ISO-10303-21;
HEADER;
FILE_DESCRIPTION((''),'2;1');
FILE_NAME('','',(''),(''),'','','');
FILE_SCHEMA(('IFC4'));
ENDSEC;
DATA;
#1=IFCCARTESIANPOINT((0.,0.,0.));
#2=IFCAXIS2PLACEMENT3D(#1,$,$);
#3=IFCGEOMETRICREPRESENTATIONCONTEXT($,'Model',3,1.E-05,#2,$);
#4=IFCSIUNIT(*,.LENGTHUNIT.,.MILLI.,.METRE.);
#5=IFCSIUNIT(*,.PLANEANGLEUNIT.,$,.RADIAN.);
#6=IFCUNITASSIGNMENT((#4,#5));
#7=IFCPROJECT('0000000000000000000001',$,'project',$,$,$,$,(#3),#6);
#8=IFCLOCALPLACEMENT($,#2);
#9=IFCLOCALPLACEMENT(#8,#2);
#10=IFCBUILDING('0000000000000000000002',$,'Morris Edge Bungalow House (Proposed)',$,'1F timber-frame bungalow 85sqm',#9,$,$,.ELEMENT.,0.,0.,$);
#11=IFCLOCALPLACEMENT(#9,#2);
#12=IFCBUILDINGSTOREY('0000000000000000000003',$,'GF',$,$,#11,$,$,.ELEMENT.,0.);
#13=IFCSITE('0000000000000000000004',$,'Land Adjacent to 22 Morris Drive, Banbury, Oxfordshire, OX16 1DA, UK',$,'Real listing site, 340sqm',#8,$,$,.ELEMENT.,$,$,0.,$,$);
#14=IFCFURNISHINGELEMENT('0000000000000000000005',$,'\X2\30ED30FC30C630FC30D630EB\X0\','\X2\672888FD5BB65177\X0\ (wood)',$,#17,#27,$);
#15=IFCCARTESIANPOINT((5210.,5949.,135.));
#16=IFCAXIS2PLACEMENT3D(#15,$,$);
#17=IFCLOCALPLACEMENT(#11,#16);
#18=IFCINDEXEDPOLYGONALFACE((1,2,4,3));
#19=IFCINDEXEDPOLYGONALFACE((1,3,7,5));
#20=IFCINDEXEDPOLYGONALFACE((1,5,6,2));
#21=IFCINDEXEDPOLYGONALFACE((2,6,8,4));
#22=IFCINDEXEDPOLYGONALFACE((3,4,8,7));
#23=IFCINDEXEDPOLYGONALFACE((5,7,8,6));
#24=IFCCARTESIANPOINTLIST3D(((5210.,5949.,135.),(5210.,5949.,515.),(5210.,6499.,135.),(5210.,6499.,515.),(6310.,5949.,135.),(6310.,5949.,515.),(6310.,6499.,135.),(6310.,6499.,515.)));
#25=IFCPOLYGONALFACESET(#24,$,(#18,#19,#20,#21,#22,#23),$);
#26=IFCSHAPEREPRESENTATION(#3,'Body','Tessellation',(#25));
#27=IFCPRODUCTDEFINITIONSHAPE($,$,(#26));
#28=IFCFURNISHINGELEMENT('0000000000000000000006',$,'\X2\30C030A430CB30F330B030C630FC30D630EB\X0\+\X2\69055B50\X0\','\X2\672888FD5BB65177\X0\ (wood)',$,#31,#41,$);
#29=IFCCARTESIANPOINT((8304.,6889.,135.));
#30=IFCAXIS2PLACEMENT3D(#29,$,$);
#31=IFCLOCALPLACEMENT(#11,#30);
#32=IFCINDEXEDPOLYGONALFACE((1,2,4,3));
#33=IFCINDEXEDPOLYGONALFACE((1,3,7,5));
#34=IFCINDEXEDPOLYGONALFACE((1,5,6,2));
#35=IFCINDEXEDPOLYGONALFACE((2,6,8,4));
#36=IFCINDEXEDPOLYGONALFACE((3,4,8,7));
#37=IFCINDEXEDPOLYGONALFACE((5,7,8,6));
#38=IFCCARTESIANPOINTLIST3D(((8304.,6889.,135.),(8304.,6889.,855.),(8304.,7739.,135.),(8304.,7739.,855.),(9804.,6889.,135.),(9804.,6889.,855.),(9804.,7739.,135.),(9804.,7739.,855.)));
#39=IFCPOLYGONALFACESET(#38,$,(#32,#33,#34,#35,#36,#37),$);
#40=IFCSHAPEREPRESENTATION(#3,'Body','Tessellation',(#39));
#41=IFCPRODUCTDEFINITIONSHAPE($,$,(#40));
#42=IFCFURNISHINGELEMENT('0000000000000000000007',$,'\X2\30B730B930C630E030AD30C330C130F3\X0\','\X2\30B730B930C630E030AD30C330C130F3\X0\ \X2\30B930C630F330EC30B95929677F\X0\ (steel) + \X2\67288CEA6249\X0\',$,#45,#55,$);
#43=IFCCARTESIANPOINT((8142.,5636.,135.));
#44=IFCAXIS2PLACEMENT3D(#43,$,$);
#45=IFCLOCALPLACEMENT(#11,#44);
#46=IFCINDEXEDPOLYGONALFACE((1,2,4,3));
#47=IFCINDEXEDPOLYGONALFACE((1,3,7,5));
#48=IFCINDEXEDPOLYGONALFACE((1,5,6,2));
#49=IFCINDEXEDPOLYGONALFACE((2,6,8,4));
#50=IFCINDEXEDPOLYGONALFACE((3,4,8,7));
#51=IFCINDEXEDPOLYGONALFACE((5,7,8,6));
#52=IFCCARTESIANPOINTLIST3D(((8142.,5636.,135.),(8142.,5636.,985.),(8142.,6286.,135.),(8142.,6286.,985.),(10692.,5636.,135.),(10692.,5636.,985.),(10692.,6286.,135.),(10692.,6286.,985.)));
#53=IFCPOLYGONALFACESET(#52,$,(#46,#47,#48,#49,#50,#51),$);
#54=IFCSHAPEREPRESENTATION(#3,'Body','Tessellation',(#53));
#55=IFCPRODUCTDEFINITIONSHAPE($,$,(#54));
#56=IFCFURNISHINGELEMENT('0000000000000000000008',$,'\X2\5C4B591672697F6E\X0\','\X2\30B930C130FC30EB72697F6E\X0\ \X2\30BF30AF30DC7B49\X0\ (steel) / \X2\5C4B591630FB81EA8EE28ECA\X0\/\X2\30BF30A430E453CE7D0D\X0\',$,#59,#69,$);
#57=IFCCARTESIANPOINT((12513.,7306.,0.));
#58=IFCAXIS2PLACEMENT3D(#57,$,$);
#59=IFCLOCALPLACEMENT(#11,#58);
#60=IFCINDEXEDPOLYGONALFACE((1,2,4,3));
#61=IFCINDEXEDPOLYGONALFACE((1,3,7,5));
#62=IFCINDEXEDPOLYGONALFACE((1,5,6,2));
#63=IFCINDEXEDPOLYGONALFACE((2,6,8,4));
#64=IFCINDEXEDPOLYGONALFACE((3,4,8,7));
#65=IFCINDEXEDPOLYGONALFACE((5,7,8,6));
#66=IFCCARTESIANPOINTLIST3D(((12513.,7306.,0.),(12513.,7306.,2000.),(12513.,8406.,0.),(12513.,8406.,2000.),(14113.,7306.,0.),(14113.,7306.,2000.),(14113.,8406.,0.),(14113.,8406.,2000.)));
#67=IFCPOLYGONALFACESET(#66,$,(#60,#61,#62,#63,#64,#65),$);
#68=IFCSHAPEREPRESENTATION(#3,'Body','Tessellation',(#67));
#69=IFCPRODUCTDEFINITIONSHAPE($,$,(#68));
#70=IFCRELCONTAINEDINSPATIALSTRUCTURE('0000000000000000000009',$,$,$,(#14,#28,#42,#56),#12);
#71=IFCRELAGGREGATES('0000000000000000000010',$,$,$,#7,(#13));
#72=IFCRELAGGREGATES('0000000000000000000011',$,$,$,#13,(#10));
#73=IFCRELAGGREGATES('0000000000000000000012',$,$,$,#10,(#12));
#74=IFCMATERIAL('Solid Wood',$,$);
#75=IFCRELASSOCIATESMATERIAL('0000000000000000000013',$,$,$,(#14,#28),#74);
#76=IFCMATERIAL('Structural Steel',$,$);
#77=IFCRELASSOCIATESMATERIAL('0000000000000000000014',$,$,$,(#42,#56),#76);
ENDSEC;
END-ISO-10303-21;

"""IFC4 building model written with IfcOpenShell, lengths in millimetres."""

from ifc_helpers import new_model, si_unit, frame, frame_2d, origin, place, context, project, spatial, rectangle, extrude, material, element, save


model = new_model("IFC4")

# Units and contexts
model_context = context("Model", 3, precision=1e-05, world=origin())
ifc_project = project(units=[si_unit("LENGTHUNIT", "METRE", prefix="MILLI"), si_unit("PLANEANGLEUNIT", "RADIAN")], contexts=[model_context])

# Site, building, storey
site_placement = place(None, origin())
site = spatial("IfcSite", under=ifc_project, at=site_placement, Name="Land Adjacent to 22 Morris Drive, Banbury, Oxfordshire, OX16 1DA, UK", ObjectType="Real listing site, 340sqm", CompositionType="ELEMENT", RefElevation=0.0)
building_placement = place(site_placement, origin())
building = spatial("IfcBuilding", under=site, at=building_placement, Name="Morris Edge Bungalow House (Proposed)", ObjectType="1F timber-frame bungalow 85sqm", CompositionType="ELEMENT", ElevationOfRefHeight=0.0, ElevationOfTerrain=0.0)
storey_placement = place(building_placement, origin())
storey = spatial("IfcBuildingStorey", under=building, at=storey_placement, Name="GF", CompositionType="ELEMENT", Elevation=0.0)

# Shared definitions
ifc_material_1 = material(Name="Solid Wood")

# Shared definitions
ifc_material_2 = material(Name="Structural Steel")

# Furnishing elements
furnishing_1_placement = place(storey_placement, frame((5210.0, 5949.0, 135.0)))
element("IfcFurnishingElement", 1, at=furnishing_1_placement, inside=storey, material=ifc_material_1, Name="ローテーブル", Description="木製家具 (wood)", context=model_context, shape_type="SweptSolid", body=[
    extrude(rectangle(XDim=1100.0, YDim=550.0, at=frame_2d((550.0, 275.0))), frame((5210.0, 5949.0, 135.0)), (0.0, 0.0, 1.0), 380.0),
])
furnishing_2_placement = place(storey_placement, frame((8304.0, 6889.0, 135.0)))
element("IfcFurnishingElement", 2, at=furnishing_2_placement, inside=storey, material=ifc_material_1, Name="ダイニングテーブル+椅子", Description="木製家具 (wood)", context=model_context, shape_type="SweptSolid", body=[
    extrude(rectangle(XDim=1500.0, YDim=850.0, at=frame_2d((750.0, 425.0))), frame((8304.0, 6889.0, 135.0)), (0.0, 0.0, 1.0), 720.0),
])
furnishing_3_placement = place(storey_placement, frame((8142.0, 5636.0, 135.0)))
element("IfcFurnishingElement", 3, at=furnishing_3_placement, inside=storey, material=ifc_material_2, Name="システムキッチン", Description="システムキッチン ステンレス天板 (steel) + 木質扉", context=model_context, shape_type="SweptSolid", body=[
    extrude(rectangle(XDim=2550.0, YDim=650.0, at=frame_2d((1275.0, 325.0))), frame((8142.0, 5636.0, 135.0)), (0.0, 0.0, 1.0), 850.0),
])
furnishing_4_placement = place(storey_placement, frame((12513.0, 7306.0, 0.0)))
element("IfcFurnishingElement", 4, at=furnishing_4_placement, inside=storey, material=ifc_material_2, Name="屋外物置", Description="スチール物置 タクボ等 (steel) / 屋外・自転車/タイヤ収納", context=model_context, shape_type="SweptSolid", body=[
    extrude(rectangle(XDim=1600.0, YDim=1100.0, at=frame_2d((800.0, 550.0))), frame((12513.0, 7306.0, 0.0)), (0.0, 0.0, 1.0), 2000.0),
])

save(model, "model.ifc")
